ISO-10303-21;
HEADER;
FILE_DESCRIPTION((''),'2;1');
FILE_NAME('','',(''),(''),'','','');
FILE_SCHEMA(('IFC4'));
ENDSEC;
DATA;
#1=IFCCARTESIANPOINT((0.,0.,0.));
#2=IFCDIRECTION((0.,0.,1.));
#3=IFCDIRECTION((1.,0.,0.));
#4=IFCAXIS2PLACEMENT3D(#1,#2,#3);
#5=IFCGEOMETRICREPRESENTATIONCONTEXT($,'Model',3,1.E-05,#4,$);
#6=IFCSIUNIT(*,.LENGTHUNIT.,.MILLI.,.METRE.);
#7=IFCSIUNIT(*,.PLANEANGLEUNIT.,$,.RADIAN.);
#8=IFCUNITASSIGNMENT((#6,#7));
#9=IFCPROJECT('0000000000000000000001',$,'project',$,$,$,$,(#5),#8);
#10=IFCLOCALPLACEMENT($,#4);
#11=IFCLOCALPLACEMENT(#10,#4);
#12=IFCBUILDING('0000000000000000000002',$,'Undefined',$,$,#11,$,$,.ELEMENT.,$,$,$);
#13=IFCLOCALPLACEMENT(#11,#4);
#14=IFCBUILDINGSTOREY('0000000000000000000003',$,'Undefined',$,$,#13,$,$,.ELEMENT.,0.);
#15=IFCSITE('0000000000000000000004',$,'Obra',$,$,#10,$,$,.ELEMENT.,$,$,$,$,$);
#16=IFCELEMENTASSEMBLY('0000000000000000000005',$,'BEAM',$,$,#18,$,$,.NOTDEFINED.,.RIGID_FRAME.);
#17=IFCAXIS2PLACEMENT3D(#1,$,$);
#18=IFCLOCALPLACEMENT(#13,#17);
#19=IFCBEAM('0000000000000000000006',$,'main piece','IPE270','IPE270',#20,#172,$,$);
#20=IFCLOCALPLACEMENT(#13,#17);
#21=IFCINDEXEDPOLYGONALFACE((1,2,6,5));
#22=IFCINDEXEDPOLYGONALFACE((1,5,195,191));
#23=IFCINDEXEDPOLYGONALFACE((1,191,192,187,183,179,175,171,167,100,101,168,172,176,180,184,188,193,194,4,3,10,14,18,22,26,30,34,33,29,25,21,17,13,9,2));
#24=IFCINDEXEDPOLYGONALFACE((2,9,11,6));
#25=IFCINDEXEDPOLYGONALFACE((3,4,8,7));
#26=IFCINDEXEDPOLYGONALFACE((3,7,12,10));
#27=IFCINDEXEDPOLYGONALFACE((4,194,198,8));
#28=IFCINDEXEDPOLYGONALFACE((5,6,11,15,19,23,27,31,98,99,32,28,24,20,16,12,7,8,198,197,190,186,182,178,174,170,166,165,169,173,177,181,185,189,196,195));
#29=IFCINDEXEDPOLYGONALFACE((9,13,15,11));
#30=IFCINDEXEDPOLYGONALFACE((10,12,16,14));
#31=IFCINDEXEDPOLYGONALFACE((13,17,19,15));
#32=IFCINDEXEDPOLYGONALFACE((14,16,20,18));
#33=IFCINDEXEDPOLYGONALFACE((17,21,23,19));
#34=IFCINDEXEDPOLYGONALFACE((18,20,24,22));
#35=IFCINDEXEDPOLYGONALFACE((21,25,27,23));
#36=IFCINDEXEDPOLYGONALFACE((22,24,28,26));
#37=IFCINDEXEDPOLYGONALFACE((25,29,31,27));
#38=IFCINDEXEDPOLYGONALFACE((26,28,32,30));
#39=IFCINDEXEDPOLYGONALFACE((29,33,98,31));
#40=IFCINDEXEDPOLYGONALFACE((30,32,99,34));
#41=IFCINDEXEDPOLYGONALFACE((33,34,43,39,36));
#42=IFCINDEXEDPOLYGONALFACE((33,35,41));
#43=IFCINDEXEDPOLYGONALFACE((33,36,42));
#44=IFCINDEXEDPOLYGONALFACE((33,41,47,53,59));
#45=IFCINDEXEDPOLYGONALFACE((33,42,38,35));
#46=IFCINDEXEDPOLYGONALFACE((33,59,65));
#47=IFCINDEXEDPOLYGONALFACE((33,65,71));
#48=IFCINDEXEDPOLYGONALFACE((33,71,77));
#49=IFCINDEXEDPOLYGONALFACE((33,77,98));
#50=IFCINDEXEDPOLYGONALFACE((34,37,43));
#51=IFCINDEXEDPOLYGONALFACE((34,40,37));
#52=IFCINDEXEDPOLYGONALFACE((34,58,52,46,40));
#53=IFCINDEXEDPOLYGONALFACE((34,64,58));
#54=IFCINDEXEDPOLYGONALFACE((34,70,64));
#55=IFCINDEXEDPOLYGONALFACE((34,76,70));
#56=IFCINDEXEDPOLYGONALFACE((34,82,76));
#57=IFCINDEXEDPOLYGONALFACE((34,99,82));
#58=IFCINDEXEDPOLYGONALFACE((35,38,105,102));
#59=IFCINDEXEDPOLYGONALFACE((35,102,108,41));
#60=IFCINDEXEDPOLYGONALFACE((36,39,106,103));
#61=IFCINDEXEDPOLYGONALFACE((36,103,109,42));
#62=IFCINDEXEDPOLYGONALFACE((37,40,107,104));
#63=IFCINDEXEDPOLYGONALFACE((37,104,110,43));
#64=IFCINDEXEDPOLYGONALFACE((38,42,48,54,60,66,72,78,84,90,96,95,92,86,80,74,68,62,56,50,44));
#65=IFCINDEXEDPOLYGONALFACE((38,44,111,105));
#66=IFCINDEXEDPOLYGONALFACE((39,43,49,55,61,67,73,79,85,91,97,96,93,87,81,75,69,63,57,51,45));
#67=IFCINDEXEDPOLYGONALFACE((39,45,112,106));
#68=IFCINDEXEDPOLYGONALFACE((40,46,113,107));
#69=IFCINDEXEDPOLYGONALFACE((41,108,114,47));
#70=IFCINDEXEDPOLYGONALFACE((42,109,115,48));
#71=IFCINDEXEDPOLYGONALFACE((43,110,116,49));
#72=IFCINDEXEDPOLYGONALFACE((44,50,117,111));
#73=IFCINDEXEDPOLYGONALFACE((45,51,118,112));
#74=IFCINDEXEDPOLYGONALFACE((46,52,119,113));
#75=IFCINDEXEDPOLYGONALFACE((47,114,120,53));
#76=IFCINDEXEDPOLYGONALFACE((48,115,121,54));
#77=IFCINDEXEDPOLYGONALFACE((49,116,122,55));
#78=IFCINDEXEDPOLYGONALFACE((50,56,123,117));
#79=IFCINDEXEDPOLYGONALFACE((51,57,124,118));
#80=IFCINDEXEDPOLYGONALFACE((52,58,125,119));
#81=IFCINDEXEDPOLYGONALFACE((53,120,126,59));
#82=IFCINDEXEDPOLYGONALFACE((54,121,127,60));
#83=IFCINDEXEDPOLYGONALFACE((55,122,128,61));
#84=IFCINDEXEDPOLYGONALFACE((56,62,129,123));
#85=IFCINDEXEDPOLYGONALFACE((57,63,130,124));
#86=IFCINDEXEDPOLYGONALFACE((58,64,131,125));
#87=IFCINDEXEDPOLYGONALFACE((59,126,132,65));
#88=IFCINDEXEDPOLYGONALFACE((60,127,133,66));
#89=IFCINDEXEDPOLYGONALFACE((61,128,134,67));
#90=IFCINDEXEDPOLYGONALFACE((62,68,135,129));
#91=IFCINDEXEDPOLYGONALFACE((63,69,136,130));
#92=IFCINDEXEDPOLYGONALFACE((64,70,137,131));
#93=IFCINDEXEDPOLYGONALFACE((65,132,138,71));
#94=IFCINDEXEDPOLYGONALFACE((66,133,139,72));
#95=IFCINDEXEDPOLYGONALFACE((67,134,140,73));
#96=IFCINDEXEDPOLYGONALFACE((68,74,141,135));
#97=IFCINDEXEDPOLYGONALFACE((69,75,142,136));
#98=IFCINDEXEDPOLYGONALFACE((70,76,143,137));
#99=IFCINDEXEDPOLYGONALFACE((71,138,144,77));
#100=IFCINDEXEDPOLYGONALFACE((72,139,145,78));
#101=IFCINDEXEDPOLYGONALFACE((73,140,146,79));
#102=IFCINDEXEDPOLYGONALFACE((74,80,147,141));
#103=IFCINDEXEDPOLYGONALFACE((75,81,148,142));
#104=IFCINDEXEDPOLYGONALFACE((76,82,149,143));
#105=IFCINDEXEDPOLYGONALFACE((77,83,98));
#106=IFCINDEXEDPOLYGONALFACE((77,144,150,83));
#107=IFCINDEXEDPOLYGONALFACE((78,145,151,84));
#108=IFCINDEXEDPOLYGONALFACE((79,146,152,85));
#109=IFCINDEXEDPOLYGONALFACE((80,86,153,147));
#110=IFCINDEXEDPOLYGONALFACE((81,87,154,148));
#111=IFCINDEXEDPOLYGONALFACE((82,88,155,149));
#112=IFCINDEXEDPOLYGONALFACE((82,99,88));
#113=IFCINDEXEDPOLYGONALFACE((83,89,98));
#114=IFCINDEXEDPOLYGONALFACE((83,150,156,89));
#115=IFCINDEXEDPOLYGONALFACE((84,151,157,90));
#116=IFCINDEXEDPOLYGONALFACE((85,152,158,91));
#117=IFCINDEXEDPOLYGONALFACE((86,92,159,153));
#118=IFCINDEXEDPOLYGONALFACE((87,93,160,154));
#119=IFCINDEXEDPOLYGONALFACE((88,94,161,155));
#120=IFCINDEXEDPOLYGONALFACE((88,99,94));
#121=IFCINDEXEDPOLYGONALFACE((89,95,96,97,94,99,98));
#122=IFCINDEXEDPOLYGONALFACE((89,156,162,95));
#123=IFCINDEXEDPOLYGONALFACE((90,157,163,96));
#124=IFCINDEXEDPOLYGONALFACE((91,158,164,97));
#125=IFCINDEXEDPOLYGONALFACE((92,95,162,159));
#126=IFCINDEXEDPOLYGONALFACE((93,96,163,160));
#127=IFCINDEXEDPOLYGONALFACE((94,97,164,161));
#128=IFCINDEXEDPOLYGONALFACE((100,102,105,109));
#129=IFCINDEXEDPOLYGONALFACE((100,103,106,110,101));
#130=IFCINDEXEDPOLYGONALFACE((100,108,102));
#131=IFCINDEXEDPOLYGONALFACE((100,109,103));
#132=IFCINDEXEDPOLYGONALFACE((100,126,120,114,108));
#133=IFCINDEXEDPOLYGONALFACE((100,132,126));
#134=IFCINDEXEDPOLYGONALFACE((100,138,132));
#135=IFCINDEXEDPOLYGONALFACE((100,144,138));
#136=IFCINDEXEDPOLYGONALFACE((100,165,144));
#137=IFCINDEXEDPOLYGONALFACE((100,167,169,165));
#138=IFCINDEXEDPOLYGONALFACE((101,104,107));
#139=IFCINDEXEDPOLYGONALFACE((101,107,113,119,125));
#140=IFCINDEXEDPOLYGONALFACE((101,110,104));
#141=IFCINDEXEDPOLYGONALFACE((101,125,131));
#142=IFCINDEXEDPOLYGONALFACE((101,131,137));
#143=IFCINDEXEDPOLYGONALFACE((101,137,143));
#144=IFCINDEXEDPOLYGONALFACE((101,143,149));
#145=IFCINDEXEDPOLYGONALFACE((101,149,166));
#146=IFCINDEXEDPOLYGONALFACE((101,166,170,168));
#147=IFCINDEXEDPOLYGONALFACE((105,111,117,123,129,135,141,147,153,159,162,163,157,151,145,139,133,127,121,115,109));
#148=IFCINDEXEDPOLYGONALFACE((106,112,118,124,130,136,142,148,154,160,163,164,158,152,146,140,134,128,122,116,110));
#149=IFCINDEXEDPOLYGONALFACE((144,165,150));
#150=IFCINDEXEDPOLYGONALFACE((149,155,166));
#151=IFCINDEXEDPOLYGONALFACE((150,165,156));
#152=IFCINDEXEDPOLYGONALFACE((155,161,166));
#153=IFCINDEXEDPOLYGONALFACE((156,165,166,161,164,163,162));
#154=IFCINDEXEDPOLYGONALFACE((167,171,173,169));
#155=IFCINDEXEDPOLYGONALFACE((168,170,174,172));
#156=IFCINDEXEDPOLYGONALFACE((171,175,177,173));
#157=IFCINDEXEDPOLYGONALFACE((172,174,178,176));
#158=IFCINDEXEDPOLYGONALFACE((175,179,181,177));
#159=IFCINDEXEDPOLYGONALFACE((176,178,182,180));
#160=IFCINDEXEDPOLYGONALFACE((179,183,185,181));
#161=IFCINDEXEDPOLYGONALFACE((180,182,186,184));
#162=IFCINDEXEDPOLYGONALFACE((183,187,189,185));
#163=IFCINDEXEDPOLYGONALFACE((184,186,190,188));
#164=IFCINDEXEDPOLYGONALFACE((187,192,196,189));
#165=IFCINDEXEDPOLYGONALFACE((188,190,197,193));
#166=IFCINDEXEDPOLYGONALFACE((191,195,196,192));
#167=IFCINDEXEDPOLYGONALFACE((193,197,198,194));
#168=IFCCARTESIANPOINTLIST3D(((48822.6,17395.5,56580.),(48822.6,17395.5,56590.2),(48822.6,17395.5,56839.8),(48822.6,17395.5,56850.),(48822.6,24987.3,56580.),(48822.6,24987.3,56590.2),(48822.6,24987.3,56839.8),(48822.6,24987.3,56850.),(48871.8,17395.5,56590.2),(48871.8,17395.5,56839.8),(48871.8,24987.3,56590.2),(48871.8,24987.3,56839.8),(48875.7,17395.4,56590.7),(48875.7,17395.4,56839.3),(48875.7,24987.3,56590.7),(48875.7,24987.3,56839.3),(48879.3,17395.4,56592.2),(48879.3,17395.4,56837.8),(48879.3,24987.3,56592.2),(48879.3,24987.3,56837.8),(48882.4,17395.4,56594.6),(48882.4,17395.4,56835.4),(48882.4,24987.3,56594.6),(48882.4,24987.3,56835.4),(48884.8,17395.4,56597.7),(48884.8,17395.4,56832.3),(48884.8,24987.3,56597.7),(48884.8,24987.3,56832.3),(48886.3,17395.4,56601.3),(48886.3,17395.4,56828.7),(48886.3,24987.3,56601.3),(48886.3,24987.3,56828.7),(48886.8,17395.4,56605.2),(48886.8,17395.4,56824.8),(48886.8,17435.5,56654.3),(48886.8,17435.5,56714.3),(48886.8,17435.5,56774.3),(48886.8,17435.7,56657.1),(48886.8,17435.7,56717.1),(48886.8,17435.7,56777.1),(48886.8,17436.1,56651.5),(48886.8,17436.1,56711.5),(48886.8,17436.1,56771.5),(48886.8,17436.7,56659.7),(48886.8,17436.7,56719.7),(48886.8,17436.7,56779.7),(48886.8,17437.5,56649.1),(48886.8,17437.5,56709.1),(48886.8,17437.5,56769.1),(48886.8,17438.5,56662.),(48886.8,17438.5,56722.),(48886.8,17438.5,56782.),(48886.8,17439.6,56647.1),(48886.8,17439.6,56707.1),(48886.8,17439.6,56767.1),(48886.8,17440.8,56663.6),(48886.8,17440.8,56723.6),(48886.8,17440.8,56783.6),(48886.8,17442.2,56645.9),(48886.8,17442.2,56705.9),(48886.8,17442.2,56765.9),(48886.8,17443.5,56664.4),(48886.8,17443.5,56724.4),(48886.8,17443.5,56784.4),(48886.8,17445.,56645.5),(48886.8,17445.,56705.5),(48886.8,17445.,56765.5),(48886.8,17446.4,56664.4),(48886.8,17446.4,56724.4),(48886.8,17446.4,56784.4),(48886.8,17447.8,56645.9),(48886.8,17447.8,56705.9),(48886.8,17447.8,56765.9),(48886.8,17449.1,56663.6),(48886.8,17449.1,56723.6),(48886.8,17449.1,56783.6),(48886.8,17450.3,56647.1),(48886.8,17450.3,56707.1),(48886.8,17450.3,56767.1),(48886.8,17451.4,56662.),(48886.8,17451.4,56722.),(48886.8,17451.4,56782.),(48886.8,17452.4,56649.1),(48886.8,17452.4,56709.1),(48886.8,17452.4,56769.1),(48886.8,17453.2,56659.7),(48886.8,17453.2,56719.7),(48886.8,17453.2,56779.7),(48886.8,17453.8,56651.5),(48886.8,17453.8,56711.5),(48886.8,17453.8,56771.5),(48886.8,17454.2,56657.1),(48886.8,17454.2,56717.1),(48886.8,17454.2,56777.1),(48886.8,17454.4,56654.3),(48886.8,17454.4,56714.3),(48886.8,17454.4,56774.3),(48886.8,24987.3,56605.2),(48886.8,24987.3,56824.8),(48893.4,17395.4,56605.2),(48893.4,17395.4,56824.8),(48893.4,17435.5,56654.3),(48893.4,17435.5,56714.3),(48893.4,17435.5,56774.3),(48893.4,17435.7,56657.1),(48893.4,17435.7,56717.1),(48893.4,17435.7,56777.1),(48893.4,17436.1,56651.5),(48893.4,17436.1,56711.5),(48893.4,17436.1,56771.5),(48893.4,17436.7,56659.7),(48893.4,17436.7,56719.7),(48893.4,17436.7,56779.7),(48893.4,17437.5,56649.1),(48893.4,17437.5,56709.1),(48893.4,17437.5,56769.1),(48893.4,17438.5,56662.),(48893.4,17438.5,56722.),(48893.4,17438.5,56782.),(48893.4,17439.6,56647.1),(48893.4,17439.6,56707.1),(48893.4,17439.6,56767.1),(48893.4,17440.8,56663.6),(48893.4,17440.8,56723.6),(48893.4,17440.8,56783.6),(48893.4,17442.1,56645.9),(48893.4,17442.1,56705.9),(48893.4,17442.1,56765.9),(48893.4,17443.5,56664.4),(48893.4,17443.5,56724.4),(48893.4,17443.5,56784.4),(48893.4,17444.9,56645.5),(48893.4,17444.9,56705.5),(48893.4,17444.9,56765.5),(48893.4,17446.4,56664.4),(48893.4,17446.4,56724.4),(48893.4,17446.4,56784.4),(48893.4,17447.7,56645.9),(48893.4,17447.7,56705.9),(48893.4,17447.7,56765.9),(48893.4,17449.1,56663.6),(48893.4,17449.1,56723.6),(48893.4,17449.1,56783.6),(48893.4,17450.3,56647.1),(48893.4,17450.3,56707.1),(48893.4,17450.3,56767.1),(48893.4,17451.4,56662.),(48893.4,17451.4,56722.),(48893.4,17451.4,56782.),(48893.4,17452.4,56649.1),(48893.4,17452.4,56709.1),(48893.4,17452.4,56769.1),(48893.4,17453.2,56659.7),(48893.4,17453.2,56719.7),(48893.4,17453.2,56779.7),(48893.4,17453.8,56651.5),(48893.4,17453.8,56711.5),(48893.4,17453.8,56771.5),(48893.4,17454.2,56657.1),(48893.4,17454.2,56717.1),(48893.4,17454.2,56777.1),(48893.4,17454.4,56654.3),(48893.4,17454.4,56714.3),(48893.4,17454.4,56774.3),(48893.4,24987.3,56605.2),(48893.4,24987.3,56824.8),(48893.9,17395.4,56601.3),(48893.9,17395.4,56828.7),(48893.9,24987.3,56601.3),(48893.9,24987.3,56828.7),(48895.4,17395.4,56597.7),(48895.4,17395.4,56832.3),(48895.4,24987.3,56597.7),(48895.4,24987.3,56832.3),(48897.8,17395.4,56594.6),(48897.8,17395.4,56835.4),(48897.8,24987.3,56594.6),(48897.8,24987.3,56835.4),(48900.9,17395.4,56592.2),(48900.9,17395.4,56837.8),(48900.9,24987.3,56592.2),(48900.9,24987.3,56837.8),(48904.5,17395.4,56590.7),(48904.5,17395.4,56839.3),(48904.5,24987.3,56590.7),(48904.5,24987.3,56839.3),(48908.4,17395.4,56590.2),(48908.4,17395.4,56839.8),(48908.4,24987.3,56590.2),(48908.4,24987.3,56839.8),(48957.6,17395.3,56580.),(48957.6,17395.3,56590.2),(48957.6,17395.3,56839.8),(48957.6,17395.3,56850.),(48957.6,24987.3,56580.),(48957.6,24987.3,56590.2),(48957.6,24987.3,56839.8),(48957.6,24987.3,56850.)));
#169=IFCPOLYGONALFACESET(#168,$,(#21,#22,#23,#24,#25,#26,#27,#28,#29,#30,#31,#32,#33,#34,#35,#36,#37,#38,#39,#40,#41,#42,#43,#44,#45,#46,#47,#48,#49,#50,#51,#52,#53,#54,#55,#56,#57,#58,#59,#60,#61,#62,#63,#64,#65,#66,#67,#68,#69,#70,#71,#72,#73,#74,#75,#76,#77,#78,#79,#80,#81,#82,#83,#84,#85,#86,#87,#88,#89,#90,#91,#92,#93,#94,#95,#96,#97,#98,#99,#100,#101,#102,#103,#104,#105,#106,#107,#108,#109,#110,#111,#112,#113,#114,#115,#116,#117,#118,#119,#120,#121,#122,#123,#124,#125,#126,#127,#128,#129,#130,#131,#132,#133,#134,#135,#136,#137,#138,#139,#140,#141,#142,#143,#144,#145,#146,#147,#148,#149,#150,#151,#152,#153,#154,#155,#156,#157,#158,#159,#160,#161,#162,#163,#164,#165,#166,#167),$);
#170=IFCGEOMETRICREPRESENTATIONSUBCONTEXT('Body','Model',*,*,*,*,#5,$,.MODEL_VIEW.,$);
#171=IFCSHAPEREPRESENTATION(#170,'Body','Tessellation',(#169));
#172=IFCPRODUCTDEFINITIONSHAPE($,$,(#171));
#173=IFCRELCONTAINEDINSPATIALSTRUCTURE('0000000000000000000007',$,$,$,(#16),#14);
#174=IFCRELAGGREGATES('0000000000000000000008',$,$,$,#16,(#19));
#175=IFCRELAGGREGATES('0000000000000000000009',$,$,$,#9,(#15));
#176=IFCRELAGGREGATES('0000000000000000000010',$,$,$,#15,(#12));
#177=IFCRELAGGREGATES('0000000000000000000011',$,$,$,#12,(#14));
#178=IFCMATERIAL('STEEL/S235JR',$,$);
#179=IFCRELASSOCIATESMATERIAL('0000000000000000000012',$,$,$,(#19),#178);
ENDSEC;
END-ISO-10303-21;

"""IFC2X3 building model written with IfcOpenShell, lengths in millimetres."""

from ifc_helpers import new_model, si_unit, frame, origin_with_axes, origin_2d_with_axis, place, context, subcontext, project, spatial, circle, i_section, extrude, clip, halfspace, source, transform, mapped, material, element, aggregate, save


model = new_model("IFC2X3")

# Units and contexts
model_context = context("Model", 3, precision=1e-05, world=origin_with_axes())
body_context = subcontext(model_context, "Body", "Model", "MODEL_VIEW")
ifc_project = project(units=[si_unit("LENGTHUNIT", "METRE", prefix="MILLI"), si_unit("PLANEANGLEUNIT", "RADIAN")], contexts=[model_context])

# Site, building, storey
site_placement = place(None, origin_with_axes())
site = spatial("IfcSite", under=ifc_project, at=site_placement, Name="Obra", CompositionType="ELEMENT")
building_placement = place(site_placement, origin_with_axes())
building = spatial("IfcBuilding", under=site, at=building_placement, Name="Undefined", CompositionType="ELEMENT")
storey_placement = place(building_placement, origin_with_axes())
storey = spatial("IfcBuildingStorey", under=building, at=storey_placement, Name="Undefined", CompositionType="ELEMENT", Elevation=0.0)

# Shared definitions
ifc_material_1 = material(Name="STEEL/S235JR")

# Element assembly, beam, opening
assembly_1_placement = place(storey_placement, origin_with_axes())
assembly_1 = element("IfcElementAssembly", 1, at=assembly_1_placement, inside=storey, Name="BEAM", AssemblyPlace="NOTDEFINED", PredefinedType="RIGID_FRAME")
beam_1_placement = place(assembly_1_placement, frame((48890.1, 17374.0, 56715.0), z_axis=(0.0, 0.0, 1.0), x_axis=(0.0, 1.0, 0.0)))
beam_1 = element("IfcBeam", 2, at=beam_1_placement, material=ifc_material_1, Name="main piece", Description="IPE270", ObjectType="IPE270", context=body_context, shape_type="Clipping", body=[
    clip(extrude(i_section(OverallWidth=135.0, OverallDepth=270.0, WebThickness=6.6, FlangeThickness=10.2, FilletRadius=15.0, at=origin_2d_with_axis()), frame((7613.3, 0.0, 0.0), z_axis=(-1.0, 0.0, 0.0), x_axis=(0.0, -1.0, 0.0)), (0.0, 0.0, 1.0), 7613.3), halfspace(frame((21.5, 59.2, -120.0), z_axis=(-0.999999, 0.00163, 0.0), x_axis=(0.0, 0.0, 1.0)), False)),
])
shared_shape_1 = source(origin_with_axes(), body_context, "Body", "SweptSolid", [
    extrude(circle(Radius=9.5, at=origin_2d_with_axis()), frame((0.0, -2.5, 0.0), z_axis=(0.0, 1.0, 0.0), x_axis=(1.0, 0.0, 0.0)), (0.0, 0.0, 1.0), 6.8),
])
opening_1_placement = place(assembly_1_placement, frame((48890.9, 17395.0, 56835.0), z_axis=(0.001649, 0.999999, 0.0), x_axis=(0.0, 0.0, -1.0)))
element("IfcOpeningElement", 3, at=opening_1_placement, cuts=beam_1, ObjectType="Opening", context=body_context, shape_type="MappedRepresentation", body=[
    mapped(shared_shape_1, transform((60.0, 0.0, 50.0))),
    mapped(shared_shape_1, transform((120.0, 0.0, 50.0))),
    mapped(shared_shape_1, transform((180.0, 0.0, 50.0))),
])
aggregate(assembly_1, [beam_1])

save(model, "model.ifc")
